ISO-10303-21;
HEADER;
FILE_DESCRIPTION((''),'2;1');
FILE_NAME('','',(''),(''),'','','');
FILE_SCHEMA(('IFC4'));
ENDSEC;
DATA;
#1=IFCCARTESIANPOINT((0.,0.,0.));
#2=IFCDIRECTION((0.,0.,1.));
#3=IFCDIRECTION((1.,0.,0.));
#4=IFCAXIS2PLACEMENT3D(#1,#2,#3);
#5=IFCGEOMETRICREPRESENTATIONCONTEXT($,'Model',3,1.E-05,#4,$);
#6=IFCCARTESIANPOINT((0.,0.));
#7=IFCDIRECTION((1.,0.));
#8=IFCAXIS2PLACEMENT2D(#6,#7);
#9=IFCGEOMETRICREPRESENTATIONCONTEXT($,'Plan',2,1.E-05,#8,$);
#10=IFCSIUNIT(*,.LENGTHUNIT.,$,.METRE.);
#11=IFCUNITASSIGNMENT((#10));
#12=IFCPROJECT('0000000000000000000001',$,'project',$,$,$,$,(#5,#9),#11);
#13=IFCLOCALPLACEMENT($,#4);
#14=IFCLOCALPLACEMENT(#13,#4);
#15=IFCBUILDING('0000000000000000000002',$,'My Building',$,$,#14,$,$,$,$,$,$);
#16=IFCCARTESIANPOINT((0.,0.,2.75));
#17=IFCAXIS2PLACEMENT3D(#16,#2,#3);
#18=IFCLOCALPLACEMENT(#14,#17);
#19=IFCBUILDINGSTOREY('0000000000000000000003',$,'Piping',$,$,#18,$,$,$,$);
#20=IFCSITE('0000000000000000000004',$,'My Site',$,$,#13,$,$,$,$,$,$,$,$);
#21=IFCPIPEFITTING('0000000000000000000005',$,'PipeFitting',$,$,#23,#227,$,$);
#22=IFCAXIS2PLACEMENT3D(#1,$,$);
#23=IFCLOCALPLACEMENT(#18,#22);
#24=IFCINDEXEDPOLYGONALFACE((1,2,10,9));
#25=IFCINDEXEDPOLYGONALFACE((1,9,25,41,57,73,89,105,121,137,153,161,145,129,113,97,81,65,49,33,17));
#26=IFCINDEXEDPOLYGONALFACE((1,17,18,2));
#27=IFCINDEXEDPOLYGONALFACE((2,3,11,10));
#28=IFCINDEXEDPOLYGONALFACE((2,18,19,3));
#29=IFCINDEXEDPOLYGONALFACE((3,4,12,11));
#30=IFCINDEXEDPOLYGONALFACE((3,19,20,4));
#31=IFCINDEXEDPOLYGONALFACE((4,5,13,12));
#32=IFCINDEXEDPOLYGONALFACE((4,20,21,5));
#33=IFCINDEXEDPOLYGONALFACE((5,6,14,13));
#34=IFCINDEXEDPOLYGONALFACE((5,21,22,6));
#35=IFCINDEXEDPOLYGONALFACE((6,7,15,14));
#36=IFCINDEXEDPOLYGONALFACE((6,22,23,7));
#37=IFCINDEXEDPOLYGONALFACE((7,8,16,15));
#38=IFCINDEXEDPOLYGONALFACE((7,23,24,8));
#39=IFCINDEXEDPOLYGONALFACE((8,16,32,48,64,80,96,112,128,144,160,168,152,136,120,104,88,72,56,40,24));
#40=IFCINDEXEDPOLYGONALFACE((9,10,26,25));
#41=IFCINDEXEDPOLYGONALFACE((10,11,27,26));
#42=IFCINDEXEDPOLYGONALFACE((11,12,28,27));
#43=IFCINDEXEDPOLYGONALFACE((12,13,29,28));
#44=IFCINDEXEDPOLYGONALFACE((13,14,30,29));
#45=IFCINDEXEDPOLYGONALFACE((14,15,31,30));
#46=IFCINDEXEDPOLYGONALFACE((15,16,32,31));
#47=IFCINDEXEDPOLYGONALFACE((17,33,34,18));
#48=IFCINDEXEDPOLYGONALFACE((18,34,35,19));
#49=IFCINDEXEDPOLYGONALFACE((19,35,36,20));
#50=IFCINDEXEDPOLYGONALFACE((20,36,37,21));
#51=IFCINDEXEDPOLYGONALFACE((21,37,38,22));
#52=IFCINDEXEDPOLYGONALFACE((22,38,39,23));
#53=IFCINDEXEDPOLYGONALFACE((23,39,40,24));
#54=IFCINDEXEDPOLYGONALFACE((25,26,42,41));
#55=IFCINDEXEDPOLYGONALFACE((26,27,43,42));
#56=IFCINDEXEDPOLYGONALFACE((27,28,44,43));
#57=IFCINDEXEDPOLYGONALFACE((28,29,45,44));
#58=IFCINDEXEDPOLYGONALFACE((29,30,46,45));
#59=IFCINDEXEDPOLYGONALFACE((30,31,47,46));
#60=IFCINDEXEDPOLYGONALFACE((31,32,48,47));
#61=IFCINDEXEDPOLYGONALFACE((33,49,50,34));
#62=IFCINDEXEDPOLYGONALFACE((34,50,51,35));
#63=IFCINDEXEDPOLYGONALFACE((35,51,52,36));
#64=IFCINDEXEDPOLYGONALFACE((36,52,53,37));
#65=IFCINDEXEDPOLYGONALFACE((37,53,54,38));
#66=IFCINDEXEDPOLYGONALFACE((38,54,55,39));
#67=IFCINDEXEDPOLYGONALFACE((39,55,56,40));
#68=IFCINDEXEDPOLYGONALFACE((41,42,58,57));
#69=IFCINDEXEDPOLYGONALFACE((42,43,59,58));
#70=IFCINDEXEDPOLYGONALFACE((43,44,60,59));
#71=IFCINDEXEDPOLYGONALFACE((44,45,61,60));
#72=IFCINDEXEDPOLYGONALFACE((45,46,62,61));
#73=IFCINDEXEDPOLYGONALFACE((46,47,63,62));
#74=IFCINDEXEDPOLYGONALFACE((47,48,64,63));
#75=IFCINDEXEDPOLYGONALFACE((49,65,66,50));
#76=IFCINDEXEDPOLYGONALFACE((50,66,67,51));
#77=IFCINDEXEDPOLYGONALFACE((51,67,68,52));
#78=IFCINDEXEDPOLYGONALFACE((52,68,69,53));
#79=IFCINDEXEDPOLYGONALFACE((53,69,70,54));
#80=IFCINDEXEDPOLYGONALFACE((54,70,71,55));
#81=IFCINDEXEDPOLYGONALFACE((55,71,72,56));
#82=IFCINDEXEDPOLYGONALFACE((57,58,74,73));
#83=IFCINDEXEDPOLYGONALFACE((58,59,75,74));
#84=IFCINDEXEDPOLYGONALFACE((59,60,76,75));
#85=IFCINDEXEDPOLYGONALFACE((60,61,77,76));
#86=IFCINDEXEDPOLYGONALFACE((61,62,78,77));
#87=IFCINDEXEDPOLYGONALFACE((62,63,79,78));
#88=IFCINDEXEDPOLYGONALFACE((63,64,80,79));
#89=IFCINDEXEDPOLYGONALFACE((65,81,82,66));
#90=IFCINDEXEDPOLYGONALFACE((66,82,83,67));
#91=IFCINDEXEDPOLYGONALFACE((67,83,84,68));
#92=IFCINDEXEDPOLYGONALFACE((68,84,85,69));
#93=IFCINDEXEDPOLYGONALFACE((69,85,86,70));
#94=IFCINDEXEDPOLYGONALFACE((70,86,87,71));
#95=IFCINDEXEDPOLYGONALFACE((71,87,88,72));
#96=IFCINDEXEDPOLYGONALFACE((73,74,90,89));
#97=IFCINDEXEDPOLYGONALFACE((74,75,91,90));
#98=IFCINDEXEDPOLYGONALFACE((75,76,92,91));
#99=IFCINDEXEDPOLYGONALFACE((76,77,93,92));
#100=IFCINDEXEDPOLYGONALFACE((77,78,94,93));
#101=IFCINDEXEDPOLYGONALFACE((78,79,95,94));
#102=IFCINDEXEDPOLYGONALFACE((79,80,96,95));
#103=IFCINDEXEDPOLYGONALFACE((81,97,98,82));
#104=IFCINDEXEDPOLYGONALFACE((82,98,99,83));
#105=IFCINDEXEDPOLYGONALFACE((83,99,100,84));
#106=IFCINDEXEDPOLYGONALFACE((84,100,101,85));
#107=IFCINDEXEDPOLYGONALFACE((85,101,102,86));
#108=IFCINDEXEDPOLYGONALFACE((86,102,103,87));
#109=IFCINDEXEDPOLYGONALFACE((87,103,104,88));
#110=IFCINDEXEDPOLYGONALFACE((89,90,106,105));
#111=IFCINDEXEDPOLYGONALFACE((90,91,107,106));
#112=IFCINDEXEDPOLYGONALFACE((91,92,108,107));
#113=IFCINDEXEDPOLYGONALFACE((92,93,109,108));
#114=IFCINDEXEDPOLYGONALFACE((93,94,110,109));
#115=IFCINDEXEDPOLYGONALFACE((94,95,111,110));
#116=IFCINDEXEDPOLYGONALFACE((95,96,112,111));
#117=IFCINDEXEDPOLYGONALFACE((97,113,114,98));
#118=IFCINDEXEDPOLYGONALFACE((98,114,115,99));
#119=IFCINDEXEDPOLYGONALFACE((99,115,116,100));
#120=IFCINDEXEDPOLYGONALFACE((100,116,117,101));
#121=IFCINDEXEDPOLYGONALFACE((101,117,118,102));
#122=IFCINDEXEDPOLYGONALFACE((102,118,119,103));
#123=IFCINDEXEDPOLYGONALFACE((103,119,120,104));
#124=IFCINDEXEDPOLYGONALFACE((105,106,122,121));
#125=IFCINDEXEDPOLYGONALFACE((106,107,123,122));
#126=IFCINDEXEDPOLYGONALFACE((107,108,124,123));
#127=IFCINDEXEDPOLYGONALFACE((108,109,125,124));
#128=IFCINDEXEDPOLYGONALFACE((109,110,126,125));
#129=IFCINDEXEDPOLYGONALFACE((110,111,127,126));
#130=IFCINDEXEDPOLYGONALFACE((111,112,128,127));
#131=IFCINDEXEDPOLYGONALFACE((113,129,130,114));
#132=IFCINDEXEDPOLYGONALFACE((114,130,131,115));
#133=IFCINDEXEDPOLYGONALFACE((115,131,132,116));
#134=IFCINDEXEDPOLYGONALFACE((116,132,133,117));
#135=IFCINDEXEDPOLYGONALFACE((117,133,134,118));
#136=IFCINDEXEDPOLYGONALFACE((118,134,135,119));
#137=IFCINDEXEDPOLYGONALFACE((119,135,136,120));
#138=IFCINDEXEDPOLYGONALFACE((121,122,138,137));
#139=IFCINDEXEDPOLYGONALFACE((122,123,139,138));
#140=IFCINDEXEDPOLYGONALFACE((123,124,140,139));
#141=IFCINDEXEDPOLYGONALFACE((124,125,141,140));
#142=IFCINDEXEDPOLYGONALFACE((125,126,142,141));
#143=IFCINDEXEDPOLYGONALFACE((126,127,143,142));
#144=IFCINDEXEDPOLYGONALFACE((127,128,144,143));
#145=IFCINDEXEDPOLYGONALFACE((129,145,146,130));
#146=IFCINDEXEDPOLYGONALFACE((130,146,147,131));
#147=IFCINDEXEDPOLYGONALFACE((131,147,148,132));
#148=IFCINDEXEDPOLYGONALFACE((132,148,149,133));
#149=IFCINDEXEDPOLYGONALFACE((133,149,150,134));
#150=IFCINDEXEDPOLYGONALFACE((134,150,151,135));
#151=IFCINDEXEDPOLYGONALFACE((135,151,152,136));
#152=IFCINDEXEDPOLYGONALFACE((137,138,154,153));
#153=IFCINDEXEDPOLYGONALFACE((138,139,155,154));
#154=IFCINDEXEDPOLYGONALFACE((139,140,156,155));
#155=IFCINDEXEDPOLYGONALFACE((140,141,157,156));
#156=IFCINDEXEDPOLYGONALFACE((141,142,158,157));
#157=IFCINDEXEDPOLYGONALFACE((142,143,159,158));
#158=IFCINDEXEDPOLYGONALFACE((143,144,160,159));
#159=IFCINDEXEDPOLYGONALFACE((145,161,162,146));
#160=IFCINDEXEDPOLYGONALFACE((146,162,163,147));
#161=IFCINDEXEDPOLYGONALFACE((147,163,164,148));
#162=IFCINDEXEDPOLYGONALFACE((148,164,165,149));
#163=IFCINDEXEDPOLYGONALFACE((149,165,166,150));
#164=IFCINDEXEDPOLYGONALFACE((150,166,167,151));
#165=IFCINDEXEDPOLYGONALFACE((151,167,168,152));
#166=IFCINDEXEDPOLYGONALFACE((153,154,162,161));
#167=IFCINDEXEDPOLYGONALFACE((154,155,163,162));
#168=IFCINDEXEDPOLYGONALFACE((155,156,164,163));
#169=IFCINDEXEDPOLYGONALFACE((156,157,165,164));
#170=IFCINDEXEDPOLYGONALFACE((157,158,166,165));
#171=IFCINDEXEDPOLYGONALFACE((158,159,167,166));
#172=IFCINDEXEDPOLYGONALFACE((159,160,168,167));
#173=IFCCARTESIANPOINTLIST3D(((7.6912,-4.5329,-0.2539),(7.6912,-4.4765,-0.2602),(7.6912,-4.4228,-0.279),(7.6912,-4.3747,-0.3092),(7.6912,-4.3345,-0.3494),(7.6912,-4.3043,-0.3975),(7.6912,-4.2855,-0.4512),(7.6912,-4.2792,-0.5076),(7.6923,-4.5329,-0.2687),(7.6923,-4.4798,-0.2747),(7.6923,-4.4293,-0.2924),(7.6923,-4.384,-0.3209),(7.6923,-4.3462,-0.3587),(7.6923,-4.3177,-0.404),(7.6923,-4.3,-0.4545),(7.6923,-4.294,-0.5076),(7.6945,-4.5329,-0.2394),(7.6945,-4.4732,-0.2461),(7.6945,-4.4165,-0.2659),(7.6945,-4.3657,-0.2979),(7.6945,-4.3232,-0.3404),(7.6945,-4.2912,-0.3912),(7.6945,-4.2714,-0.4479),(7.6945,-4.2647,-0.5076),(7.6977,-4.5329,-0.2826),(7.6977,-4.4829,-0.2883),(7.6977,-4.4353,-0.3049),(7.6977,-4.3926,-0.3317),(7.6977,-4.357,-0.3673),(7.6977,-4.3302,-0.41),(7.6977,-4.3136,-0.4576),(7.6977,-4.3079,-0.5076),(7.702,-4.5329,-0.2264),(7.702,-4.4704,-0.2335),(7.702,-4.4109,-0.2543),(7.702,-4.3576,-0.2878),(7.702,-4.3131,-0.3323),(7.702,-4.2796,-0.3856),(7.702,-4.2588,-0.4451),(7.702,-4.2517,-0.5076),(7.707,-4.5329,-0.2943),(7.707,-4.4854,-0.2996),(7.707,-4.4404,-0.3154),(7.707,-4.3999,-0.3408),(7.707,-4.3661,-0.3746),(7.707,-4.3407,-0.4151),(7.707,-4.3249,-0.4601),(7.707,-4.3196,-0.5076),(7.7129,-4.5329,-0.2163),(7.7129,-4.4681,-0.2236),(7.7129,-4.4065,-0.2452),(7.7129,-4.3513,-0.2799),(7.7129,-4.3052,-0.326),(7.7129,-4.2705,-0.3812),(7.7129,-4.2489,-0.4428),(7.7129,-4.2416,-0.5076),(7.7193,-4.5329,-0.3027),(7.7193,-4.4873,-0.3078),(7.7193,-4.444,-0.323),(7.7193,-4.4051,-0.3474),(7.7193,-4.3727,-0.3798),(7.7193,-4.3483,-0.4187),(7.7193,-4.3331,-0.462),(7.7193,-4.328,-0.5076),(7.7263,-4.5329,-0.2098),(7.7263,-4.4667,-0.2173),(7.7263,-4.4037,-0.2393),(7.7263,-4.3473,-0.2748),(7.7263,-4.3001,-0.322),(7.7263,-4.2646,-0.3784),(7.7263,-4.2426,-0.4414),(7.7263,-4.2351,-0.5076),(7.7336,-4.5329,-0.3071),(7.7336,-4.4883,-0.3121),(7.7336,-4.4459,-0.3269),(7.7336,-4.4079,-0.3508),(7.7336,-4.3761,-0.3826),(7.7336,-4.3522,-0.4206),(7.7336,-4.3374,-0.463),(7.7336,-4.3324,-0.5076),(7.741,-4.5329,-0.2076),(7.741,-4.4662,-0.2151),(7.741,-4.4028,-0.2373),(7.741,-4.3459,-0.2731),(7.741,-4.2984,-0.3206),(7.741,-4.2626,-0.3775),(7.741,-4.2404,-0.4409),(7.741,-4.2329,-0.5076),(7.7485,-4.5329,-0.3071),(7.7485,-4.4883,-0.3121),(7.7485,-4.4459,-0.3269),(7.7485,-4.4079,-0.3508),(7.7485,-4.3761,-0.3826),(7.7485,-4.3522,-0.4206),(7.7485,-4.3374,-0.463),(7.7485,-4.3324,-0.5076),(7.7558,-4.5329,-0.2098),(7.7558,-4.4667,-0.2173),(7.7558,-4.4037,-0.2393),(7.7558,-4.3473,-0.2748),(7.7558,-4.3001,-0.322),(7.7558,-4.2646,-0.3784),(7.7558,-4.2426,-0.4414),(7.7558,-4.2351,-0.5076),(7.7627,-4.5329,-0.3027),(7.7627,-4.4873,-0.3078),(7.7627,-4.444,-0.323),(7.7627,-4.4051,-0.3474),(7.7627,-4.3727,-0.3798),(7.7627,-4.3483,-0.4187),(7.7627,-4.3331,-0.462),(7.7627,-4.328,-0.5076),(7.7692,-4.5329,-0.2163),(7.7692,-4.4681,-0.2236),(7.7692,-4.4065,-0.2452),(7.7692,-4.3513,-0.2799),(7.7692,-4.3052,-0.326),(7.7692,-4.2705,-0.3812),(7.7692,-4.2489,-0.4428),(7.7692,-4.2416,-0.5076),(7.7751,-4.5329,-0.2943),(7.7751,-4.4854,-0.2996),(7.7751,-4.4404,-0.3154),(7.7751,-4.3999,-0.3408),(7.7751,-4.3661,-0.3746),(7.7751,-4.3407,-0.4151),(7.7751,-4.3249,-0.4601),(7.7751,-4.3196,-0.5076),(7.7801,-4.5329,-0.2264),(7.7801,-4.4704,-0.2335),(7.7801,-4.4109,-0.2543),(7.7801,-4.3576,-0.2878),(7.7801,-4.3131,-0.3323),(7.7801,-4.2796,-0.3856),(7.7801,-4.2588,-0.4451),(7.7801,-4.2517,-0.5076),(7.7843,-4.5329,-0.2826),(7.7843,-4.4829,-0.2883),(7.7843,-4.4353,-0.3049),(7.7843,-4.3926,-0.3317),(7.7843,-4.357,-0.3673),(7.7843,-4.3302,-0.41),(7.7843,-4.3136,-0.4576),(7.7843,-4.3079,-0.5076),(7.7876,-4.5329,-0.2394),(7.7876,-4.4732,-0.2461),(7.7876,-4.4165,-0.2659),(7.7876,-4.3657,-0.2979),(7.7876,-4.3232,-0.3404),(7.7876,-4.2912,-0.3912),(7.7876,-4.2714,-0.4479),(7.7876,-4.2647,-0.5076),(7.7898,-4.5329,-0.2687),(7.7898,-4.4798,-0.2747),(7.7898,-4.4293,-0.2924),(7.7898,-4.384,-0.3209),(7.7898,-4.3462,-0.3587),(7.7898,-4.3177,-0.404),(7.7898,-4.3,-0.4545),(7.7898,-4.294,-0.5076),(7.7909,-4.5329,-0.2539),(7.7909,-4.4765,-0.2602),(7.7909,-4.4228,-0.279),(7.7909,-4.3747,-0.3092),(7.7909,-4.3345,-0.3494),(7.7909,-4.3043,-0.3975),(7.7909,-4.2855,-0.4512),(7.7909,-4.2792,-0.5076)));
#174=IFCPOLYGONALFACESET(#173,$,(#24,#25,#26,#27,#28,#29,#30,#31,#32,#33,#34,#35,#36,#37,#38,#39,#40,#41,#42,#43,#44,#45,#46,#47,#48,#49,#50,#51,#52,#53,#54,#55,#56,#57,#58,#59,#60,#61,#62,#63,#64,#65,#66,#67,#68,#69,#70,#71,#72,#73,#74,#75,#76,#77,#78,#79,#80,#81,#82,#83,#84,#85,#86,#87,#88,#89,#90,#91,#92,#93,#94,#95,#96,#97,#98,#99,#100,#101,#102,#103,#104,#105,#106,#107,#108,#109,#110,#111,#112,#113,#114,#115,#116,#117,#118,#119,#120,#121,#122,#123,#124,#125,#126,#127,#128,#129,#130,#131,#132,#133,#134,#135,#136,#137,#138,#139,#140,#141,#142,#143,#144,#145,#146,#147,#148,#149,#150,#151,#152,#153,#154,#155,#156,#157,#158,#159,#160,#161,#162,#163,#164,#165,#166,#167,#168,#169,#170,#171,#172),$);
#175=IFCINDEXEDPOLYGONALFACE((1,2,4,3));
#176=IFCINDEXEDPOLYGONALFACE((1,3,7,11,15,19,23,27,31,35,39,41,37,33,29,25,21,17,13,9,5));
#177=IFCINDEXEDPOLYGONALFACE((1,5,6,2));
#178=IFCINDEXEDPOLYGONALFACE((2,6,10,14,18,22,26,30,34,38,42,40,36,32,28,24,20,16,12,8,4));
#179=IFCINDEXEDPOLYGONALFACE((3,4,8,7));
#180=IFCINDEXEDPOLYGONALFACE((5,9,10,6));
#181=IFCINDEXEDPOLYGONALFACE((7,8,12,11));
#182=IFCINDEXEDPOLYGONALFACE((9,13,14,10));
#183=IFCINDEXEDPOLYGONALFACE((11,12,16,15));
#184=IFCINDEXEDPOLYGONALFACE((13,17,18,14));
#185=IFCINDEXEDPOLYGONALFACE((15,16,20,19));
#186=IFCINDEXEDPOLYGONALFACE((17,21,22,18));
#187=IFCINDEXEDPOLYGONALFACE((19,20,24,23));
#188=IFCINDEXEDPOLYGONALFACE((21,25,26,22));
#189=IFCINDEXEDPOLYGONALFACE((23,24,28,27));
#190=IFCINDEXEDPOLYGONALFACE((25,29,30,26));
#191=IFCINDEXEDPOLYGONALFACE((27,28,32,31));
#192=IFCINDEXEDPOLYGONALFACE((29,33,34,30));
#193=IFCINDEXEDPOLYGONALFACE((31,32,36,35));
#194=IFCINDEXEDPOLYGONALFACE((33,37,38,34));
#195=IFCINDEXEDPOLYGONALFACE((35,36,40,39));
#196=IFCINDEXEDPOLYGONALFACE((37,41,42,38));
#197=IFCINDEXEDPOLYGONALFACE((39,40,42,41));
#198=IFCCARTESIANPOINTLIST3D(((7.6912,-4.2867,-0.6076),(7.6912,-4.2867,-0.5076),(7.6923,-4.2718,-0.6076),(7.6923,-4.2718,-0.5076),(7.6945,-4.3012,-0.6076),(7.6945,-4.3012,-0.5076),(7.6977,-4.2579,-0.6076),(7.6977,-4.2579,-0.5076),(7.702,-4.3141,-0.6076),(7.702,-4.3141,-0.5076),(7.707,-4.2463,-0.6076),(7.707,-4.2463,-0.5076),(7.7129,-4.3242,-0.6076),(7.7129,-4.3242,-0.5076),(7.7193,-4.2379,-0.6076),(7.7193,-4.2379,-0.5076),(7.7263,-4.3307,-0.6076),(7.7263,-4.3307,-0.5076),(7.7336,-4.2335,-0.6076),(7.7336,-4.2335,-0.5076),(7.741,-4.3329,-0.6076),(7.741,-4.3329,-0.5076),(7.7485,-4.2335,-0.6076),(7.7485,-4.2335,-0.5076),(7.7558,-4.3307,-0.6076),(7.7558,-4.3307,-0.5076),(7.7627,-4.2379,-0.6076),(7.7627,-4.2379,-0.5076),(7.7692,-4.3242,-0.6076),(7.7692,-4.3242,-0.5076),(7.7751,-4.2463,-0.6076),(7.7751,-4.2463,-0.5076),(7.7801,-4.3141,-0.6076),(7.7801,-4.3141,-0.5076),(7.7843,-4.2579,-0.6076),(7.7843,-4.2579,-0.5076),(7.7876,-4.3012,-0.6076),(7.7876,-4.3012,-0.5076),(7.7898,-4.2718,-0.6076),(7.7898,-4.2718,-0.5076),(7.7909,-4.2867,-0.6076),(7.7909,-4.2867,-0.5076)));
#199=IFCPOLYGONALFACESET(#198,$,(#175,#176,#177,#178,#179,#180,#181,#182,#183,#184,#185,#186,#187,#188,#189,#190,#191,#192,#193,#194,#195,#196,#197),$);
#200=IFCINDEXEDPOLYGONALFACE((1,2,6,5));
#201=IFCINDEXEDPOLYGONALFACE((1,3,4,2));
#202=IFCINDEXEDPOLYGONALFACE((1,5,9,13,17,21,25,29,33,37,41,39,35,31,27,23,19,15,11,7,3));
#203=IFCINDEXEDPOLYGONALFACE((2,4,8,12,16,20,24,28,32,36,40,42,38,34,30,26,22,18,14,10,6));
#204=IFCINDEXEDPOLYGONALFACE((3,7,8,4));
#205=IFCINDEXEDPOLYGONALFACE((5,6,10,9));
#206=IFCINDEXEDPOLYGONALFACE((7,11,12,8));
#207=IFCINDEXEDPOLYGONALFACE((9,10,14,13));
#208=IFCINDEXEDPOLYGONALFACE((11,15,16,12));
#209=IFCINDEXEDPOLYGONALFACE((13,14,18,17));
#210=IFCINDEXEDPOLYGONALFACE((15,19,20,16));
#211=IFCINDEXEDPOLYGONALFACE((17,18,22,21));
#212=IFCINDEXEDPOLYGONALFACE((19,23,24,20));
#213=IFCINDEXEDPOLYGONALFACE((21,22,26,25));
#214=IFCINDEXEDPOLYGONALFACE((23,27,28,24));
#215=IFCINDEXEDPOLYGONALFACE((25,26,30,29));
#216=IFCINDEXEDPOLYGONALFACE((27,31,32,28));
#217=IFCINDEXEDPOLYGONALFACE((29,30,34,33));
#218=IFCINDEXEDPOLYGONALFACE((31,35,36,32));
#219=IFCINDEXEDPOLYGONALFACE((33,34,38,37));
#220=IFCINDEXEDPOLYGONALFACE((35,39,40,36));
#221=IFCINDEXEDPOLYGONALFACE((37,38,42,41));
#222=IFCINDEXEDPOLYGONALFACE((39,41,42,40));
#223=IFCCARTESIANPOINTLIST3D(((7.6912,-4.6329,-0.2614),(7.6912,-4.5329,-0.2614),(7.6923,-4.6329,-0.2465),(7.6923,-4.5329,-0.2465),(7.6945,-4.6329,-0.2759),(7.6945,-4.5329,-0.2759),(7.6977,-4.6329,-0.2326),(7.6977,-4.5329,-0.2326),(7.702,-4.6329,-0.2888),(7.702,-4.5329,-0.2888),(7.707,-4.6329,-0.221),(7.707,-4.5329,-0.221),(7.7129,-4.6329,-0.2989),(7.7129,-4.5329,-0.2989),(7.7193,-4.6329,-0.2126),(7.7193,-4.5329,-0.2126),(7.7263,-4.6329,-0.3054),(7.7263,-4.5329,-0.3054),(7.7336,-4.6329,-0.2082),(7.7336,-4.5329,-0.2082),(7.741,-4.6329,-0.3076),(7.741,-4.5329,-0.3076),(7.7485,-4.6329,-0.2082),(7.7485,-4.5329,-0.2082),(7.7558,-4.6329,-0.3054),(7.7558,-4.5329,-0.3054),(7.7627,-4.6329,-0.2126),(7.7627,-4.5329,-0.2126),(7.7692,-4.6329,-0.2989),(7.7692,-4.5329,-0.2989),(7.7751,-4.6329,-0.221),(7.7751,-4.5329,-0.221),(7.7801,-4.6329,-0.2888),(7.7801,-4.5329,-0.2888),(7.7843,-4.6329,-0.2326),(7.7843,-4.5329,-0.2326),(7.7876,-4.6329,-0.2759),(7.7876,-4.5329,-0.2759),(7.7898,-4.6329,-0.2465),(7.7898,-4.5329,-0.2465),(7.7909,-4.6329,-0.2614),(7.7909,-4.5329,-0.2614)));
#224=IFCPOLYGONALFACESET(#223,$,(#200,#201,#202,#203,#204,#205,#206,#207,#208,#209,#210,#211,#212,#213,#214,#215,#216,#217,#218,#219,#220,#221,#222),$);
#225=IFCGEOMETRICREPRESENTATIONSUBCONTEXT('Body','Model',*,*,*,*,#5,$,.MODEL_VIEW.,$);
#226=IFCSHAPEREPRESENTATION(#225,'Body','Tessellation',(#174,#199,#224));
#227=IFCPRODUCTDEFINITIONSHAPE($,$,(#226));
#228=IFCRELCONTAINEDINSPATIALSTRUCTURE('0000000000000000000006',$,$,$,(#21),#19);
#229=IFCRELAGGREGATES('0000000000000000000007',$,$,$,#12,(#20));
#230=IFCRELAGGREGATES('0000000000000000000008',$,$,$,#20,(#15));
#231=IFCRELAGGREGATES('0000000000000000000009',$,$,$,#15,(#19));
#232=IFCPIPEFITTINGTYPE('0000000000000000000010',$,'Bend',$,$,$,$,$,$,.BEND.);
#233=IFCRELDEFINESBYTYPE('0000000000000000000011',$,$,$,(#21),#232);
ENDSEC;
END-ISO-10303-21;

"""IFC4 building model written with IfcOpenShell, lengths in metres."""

from ifc_helpers import new_model, entity, si_unit, frame, origin_with_axes, origin_2d_with_axis, place, context, subcontext, project, spatial, circle, extrude, source, transform, mapped, type_object, type_shapes, element, save


model = new_model("IFC4")

# Units and contexts
model_context = context("Model", 3, precision=1e-05, world=origin_with_axes())
plan_context = context("Plan", 2, precision=1e-05, world=origin_2d_with_axis())
body_context = subcontext(model_context, "Body", "Model", "MODEL_VIEW")
ifc_project = project(units=[si_unit("LENGTHUNIT", "METRE")], contexts=[model_context, plan_context])

# Site, building, storey
site_placement = place(None, origin_with_axes())
site = spatial("IfcSite", under=ifc_project, at=site_placement, Name="My Site")
building_placement = place(site_placement, origin_with_axes())
building = spatial("IfcBuilding", under=site, at=building_placement, Name="My Building")
storey_placement = place(building_placement, frame((0.0, 0.0, 2.75), z_axis=(0.0, 0.0, 1.0), x_axis=(1.0, 0.0, 0.0)))
storey = spatial("IfcBuildingStorey", under=building, at=storey_placement, Name="Piping")

# Pipe fitting
pipe_fitting_type = type_object("IfcPipeFittingType", Name="Bend", PredefinedType="BEND")
shared_shape = source(origin_with_axes(), body_context, "Body", "SolidModel", [
    entity("IfcSweptDiskSolid", entity("IfcIndexedPolyCurve", entity("IfcCartesianPointList3D", [[0.0, 0.0, -0.1], [0.0732, 0.0, -0.2768], [0.25, 0.0, -0.35]]), [entity("IfcArcIndex", [1, 2, 3])]), 0.05),
    extrude(circle(Radius=0.05), origin_with_axes(), (0.0, 0.0, -1.0), 0.1),
    extrude(circle(Radius=0.05), frame((0.25, 0.0, -0.35), z_axis=(1.0, 0.0, 0.0), x_axis=(0.0, 0.0, 1.0)), (0.0, 0.0, 1.0), 0.1),
])
type_shapes(pipe_fitting_type, [shared_shape])
for number, where, z_axis, x_axis, name in (
    (1, (7.741, -4.2829, -0.6076), (0.0, 0.0, -1.0), (0.0, -1.0, 0.0), "PipeFitting"),
):
    element("IfcPipeFitting", number, at=place(storey_placement, frame(where, z_axis=z_axis, x_axis=x_axis)), inside=storey, type_object=pipe_fitting_type, Name=name, context=body_context, shape_type="MappedRepresentation", body=[
        mapped(shared_shape, transform((0.0, 0.0, 0.0), x_axis=(1.0, 0.0, 0.0), y_axis=(0.0, 1.0, 0.0), z_axis=(0.0, 0.0, 1.0), scale=1.0)),
    ])

save(model, "model.ifc")
